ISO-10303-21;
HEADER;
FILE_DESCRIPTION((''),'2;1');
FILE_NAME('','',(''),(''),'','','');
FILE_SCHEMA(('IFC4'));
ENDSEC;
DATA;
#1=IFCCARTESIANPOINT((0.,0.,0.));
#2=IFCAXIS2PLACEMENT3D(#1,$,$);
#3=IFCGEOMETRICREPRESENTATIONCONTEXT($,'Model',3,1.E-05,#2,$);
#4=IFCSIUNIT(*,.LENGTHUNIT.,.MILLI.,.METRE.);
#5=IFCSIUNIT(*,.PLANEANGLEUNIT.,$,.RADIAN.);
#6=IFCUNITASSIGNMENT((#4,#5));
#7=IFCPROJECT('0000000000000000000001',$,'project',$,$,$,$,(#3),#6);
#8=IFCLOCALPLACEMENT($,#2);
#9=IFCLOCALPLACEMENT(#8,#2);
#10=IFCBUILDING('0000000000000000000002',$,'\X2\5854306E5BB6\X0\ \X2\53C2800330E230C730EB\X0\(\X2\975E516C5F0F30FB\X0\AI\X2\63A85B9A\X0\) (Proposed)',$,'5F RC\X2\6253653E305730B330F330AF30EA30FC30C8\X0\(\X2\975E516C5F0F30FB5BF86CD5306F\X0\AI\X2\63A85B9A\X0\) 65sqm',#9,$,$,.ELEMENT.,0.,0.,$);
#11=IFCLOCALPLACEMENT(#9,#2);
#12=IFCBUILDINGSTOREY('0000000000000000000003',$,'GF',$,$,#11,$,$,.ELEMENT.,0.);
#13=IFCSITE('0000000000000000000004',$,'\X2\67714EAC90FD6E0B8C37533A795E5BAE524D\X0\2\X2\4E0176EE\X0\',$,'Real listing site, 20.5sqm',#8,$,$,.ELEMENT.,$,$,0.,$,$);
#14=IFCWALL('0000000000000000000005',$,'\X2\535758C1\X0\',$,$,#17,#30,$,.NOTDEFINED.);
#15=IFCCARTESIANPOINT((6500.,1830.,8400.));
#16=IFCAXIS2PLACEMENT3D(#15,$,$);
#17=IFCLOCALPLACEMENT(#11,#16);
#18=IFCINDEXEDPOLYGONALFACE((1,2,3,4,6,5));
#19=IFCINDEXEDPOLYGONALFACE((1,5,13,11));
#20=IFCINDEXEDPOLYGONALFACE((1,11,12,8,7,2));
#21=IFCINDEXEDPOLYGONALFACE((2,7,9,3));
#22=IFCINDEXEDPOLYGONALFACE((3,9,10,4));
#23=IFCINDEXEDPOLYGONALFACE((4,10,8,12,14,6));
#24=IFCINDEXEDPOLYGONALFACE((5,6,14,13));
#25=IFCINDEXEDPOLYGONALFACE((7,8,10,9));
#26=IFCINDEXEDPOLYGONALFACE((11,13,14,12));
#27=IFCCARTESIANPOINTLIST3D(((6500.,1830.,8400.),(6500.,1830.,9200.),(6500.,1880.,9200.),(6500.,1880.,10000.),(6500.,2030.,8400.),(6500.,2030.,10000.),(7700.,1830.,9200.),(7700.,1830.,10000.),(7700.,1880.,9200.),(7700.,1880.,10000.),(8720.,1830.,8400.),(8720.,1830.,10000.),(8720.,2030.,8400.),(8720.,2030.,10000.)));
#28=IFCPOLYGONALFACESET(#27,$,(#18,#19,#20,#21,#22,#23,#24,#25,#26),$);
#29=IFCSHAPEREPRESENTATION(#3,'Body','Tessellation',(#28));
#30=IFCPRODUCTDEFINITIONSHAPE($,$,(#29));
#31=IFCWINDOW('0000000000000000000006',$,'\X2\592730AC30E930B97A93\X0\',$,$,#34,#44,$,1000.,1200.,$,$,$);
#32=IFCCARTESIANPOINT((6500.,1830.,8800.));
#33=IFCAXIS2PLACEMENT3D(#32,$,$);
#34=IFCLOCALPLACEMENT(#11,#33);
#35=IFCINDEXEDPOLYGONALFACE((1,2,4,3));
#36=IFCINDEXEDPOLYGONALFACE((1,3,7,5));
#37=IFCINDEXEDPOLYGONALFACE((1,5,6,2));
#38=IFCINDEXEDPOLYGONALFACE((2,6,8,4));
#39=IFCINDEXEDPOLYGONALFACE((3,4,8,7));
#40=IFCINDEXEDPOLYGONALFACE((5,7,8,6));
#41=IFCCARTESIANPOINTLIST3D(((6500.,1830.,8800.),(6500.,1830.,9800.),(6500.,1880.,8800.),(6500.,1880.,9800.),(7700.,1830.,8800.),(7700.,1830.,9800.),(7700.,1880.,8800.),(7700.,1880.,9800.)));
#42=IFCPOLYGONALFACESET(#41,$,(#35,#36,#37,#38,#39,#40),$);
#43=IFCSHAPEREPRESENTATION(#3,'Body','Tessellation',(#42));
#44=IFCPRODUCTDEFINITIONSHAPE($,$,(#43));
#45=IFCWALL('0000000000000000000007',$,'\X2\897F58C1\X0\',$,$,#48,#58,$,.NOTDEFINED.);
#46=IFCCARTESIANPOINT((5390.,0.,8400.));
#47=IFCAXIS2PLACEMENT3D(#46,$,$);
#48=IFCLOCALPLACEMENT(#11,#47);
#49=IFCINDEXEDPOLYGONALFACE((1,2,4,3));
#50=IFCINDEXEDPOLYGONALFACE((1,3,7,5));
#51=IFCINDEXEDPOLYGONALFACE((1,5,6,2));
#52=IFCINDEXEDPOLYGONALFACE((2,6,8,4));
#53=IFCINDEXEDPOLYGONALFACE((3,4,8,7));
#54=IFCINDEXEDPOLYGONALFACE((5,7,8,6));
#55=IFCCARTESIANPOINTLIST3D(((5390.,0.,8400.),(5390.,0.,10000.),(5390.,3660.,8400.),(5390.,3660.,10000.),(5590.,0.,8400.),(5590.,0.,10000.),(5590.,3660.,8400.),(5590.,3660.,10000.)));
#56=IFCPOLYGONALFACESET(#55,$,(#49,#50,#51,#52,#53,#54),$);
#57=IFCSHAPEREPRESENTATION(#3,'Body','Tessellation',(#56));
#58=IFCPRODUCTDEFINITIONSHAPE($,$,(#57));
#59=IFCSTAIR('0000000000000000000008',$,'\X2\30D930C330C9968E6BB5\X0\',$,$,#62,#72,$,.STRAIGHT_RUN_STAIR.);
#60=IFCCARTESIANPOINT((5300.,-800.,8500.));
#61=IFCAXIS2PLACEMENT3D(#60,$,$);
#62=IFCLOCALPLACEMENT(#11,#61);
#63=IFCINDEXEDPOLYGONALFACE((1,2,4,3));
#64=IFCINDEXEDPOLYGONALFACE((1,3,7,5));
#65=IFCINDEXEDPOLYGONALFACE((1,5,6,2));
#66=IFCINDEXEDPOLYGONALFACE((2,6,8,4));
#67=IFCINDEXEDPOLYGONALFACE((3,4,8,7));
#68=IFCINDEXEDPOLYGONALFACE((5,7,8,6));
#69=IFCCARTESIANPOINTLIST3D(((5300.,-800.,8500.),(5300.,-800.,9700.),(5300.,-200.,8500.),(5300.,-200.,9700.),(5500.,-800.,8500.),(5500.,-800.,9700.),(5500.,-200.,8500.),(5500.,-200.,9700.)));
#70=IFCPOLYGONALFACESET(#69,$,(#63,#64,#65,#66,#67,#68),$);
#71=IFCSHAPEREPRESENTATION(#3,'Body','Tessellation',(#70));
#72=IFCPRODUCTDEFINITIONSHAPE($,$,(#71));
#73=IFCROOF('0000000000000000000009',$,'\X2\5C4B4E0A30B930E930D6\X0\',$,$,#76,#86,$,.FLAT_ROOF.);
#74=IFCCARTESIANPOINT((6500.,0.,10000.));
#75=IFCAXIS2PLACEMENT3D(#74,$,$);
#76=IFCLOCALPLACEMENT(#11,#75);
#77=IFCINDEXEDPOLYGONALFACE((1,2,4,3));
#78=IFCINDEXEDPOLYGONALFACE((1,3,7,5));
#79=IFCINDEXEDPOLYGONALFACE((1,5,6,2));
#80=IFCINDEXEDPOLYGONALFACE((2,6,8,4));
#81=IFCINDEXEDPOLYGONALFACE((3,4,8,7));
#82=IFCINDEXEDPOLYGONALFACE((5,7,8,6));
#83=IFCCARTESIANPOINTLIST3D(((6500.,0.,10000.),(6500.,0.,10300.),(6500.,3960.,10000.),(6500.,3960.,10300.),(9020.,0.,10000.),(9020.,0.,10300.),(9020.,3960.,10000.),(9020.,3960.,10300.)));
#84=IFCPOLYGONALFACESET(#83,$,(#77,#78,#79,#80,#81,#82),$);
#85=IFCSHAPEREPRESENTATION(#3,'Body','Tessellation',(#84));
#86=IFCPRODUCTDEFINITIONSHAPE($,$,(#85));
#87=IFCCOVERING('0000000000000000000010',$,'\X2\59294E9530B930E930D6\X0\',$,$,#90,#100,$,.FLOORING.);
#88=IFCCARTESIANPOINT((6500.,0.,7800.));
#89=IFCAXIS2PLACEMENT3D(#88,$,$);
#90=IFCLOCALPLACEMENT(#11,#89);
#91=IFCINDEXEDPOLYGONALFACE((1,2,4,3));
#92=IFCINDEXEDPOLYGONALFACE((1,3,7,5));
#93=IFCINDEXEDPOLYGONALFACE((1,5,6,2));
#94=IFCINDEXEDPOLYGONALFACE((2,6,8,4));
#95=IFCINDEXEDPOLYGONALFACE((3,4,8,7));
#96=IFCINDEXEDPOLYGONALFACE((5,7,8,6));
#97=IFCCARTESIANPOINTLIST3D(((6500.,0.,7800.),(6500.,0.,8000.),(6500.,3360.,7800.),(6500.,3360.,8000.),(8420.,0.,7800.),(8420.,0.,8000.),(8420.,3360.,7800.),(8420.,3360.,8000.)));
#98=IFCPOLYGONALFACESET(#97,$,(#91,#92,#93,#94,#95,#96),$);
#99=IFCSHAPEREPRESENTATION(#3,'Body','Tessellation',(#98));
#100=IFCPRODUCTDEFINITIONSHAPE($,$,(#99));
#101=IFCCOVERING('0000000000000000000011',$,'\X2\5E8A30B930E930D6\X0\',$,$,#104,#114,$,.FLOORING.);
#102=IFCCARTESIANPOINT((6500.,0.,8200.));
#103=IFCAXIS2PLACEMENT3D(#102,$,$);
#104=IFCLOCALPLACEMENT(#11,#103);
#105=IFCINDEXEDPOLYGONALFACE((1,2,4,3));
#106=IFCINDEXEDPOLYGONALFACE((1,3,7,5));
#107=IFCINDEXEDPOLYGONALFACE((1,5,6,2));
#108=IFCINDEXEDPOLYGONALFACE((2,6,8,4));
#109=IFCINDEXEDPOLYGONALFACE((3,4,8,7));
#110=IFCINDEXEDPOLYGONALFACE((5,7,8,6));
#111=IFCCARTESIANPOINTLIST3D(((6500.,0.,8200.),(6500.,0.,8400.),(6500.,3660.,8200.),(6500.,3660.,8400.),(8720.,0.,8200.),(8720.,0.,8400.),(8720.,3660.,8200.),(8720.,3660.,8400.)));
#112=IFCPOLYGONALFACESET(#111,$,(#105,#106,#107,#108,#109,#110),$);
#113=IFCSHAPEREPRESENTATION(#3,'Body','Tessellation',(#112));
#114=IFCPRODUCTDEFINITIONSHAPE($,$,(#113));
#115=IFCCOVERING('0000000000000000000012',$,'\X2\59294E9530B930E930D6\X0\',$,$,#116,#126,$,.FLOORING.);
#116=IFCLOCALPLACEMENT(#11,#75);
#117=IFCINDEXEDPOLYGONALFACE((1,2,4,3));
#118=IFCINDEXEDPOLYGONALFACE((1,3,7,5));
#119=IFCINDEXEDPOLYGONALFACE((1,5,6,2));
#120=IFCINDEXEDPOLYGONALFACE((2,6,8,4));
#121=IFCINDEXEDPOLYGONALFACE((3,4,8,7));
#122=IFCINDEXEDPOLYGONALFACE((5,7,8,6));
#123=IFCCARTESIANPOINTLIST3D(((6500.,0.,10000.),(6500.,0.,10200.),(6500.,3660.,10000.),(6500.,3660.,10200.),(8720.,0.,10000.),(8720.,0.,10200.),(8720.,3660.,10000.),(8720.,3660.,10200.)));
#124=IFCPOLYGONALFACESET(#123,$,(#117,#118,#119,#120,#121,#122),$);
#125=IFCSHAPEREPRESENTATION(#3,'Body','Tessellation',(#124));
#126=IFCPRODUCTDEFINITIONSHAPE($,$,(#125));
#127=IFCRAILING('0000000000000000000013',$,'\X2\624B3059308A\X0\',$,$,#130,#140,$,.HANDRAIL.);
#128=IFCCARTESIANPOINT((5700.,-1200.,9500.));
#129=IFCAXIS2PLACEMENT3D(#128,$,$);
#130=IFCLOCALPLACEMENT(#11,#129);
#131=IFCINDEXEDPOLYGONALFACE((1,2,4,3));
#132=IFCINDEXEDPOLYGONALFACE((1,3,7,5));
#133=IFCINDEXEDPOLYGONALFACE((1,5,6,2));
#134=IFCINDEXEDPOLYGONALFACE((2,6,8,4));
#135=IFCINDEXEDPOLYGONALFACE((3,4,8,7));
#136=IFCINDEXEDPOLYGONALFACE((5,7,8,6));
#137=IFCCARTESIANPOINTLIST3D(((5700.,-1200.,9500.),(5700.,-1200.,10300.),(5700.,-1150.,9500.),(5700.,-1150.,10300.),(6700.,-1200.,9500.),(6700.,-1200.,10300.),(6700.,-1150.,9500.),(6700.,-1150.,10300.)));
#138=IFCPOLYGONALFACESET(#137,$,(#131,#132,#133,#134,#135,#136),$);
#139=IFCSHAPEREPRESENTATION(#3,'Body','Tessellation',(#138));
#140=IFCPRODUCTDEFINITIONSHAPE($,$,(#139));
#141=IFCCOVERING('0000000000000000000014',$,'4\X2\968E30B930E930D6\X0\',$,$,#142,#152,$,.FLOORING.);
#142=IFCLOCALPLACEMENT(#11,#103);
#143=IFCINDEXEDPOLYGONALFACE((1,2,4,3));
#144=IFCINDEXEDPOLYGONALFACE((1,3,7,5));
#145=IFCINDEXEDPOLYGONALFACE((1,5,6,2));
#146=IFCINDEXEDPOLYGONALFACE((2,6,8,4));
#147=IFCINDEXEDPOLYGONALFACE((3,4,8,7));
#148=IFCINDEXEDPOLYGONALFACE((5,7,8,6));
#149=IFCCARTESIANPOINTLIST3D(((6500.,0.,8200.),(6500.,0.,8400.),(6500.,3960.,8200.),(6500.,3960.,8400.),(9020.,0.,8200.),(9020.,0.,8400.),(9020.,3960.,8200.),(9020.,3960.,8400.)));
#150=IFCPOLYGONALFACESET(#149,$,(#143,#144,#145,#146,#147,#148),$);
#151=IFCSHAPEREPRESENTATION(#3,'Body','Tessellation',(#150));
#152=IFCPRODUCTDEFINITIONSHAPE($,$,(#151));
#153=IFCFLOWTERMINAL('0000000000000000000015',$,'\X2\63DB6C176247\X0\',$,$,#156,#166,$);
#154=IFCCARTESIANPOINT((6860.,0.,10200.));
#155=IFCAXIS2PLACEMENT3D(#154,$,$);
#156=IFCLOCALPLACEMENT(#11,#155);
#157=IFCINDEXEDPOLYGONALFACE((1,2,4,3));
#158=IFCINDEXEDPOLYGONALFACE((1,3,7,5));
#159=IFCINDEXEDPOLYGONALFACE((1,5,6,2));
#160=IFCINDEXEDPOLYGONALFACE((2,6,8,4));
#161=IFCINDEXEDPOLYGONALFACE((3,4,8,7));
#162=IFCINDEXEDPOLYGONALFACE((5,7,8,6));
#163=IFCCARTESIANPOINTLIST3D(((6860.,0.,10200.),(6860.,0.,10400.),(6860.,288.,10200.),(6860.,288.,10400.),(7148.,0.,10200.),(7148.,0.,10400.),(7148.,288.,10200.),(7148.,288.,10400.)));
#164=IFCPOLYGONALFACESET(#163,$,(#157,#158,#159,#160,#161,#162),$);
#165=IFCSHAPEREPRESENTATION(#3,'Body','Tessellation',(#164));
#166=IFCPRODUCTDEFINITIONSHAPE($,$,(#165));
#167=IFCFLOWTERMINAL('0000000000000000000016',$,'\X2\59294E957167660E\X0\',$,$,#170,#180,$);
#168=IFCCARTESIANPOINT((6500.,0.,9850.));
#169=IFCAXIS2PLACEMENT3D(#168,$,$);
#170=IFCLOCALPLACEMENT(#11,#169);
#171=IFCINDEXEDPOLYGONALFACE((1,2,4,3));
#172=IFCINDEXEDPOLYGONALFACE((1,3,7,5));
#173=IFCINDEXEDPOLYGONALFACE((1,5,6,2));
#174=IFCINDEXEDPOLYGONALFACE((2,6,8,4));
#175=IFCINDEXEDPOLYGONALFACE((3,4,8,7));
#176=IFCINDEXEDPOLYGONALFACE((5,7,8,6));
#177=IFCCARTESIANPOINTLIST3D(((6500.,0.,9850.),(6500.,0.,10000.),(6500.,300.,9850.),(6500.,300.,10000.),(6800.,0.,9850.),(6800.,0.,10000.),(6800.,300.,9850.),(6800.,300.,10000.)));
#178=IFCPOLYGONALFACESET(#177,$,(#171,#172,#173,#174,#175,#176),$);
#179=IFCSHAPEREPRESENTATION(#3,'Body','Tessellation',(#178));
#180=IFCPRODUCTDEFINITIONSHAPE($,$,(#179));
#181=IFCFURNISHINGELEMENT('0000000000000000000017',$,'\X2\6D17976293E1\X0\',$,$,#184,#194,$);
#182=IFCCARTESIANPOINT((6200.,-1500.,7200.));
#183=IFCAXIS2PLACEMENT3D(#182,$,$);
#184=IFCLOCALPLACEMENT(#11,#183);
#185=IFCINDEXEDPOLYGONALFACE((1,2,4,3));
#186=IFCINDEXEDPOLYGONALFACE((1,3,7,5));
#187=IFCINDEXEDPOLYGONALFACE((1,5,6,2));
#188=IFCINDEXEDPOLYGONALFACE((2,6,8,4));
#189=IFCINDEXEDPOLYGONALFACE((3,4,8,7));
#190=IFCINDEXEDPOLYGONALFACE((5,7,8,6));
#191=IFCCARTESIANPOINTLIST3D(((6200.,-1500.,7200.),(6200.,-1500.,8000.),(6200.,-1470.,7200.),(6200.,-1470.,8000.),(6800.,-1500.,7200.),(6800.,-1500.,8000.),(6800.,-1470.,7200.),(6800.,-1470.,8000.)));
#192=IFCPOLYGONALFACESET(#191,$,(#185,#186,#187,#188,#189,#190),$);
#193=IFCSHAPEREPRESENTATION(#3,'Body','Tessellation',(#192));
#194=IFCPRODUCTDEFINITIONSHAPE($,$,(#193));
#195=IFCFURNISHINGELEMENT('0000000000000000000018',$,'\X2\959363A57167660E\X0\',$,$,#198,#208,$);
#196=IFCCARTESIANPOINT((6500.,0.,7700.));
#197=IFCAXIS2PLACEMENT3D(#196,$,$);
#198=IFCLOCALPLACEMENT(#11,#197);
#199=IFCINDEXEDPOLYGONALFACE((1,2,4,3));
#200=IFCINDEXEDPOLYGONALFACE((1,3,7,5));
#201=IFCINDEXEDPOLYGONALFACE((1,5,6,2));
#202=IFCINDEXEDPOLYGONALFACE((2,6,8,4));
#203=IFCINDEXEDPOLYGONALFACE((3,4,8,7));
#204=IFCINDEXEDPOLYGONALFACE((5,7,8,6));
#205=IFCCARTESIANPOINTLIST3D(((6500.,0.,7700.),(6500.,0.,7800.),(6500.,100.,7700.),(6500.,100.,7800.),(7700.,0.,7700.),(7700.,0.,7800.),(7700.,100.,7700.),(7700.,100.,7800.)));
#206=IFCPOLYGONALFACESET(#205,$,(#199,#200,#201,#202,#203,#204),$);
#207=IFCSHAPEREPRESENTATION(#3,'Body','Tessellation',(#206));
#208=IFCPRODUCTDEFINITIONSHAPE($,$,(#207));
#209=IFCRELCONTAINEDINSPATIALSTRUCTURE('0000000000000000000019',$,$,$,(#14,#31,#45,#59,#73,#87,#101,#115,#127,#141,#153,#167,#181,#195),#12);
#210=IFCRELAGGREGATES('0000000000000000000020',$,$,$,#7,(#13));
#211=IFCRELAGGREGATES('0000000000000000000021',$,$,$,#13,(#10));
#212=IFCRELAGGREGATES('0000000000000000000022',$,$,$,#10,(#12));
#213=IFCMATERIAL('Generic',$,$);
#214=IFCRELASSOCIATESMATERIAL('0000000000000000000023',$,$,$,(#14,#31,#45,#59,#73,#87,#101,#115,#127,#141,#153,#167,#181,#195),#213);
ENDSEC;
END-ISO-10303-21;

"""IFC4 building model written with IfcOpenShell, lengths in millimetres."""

from ifc_helpers import new_model, si_unit, frame, frame_2d, origin, place, context, project, spatial, rectangle, extrude, material, element, fill, save


model = new_model("IFC4")

# Units and contexts
model_context = context("Model", 3, precision=1e-05, world=origin())
ifc_project = project(units=[si_unit("LENGTHUNIT", "METRE", prefix="MILLI"), si_unit("PLANEANGLEUNIT", "RADIAN")], contexts=[model_context])

# Site, building, storey
site_placement = place(None, origin())
site = spatial("IfcSite", under=ifc_project, at=site_placement, Name="東京都渋谷区神宮前2丁目", ObjectType="Real listing site, 20.5sqm", CompositionType="ELEMENT", RefElevation=0.0)
building_placement = place(site_placement, origin())
building = spatial("IfcBuilding", under=site, at=building_placement, Name="塔の家 参考モデル(非公式・AI推定) (Proposed)", ObjectType="5F RC打放しコンクリート(非公式・寸法はAI推定) 65sqm", CompositionType="ELEMENT", ElevationOfRefHeight=0.0, ElevationOfTerrain=0.0)
storey_placement = place(building_placement, origin())
storey = spatial("IfcBuildingStorey", under=building, at=storey_placement, Name="GF", CompositionType="ELEMENT", Elevation=0.0)

# Shared definitions
ifc_material = material(Name="Generic")

# Wall, opening, window
wall_1_placement = place(storey_placement, frame((6500.0, 1830.0, 8400.0)))
wall_1 = element("IfcWall", 1, at=wall_1_placement, inside=storey, material=ifc_material, Name="南壁", PredefinedType="NOTDEFINED", context=model_context, shape_type="SweptSolid", body=[
    extrude(rectangle(XDim=2220.0, YDim=200.0, at=frame_2d((1110.0, 100.0))), frame((6500.0, 1830.0, 8400.0)), (0.0, 0.0, 1.0), 1600.0),
])
opening_1_placement = place(storey_placement, frame((6500.0, 1830.0, 8800.0)))
opening_1 = element("IfcOpeningElement", 2, at=opening_1_placement, cuts=wall_1, PredefinedType="NOTDEFINED", context=model_context, shape_type="SweptSolid", body=[
    extrude(rectangle(XDim=1200.0, YDim=50.0, at=frame_2d((600.0, 25.0))), frame((6500.0, 1830.0, 8800.0)), (0.0, 0.0, 1.0), 1000.0),
])
window_1_placement = place(storey_placement, frame((6500.0, 1830.0, 8800.0)))
window_1 = element("IfcWindow", 3, at=window_1_placement, inside=storey, material=ifc_material, Name="大ガラス窓", OverallHeight=1000.0, OverallWidth=1200.0, context=model_context, shape_type="SweptSolid", body=[
    extrude(rectangle(XDim=1200.0, YDim=50.0, at=frame_2d((600.0, 25.0))), frame((6500.0, 1830.0, 8800.0)), (0.0, 0.0, 1.0), 1000.0),
])
fill(opening_1, window_1)

# Wall
wall_2_placement = place(storey_placement, frame((5390.0, 0.0, 8400.0)))
element("IfcWall", 4, at=wall_2_placement, inside=storey, material=ifc_material, Name="西壁", PredefinedType="NOTDEFINED", context=model_context, shape_type="SweptSolid", body=[
    extrude(rectangle(XDim=200.0, YDim=3660.0, at=frame_2d((100.0, 1830.0))), frame((5390.0, 0.0, 8400.0)), (0.0, 0.0, 1.0), 1600.0),
])

# Stair
stair_placement = place(storey_placement, frame((5300.0, -800.0, 8500.0)))
element("IfcStair", 5, at=stair_placement, inside=storey, material=ifc_material, Name="ベッド階段", PredefinedType="STRAIGHT_RUN_STAIR", context=model_context, shape_type="SweptSolid", body=[
    extrude(rectangle(XDim=200.0, YDim=600.0, at=frame_2d((100.0, 300.0))), frame((5300.0, -800.0, 8500.0)), (0.0, 0.0, 1.0), 1200.0),
])

# Roof
roof_placement = place(storey_placement, frame((6500.0, 0.0, 10000.0)))
element("IfcRoof", 6, at=roof_placement, inside=storey, material=ifc_material, Name="屋上スラブ", PredefinedType="FLAT_ROOF", context=model_context, shape_type="SweptSolid", body=[
    extrude(rectangle(XDim=2520.0, YDim=3960.0, at=frame_2d((1260.0, 1980.0))), frame((6500.0, 0.0, 10000.0)), (0.0, 0.0, 1.0), 300.0),
])

# Coverings
covering_1_placement = place(storey_placement, frame((6500.0, 0.0, 7800.0)))
element("IfcCovering", 7, at=covering_1_placement, inside=storey, material=ifc_material, Name="天井スラブ", PredefinedType="FLOORING", context=model_context, shape_type="SweptSolid", body=[
    extrude(rectangle(XDim=1920.0, YDim=3360.0, at=frame_2d((960.0, 1680.0))), frame((6500.0, 0.0, 7800.0)), (0.0, 0.0, 1.0), 200.0),
])
covering_2_placement = place(storey_placement, frame((6500.0, 0.0, 8200.0)))
element("IfcCovering", 8, at=covering_2_placement, inside=storey, material=ifc_material, Name="床スラブ", PredefinedType="FLOORING", context=model_context, shape_type="SweptSolid", body=[
    extrude(rectangle(XDim=2220.0, YDim=3660.0, at=frame_2d((1110.0, 1830.0))), frame((6500.0, 0.0, 8200.0)), (0.0, 0.0, 1.0), 200.0),
])
covering_3_placement = place(storey_placement, frame((6500.0, 0.0, 10000.0)))
element("IfcCovering", 9, at=covering_3_placement, inside=storey, material=ifc_material, Name="天井スラブ", PredefinedType="FLOORING", context=model_context, shape_type="SweptSolid", body=[
    extrude(rectangle(XDim=2220.0, YDim=3660.0, at=frame_2d((1110.0, 1830.0))), frame((6500.0, 0.0, 10000.0)), (0.0, 0.0, 1.0), 200.0),
])

# Railing
railing_placement = place(storey_placement, frame((5700.0, -1200.0, 9500.0)))
element("IfcRailing", 10, at=railing_placement, inside=storey, material=ifc_material, Name="手すり", PredefinedType="HANDRAIL", context=model_context, shape_type="SweptSolid", body=[
    extrude(rectangle(XDim=1000.0, YDim=50.0, at=frame_2d((500.0, 25.0))), frame((5700.0, -1200.0, 9500.0)), (0.0, 0.0, 1.0), 800.0),
])

# Covering
covering_4_placement = place(storey_placement, frame((6500.0, 0.0, 8200.0)))
element("IfcCovering", 11, at=covering_4_placement, inside=storey, material=ifc_material, Name="4階スラブ", PredefinedType="FLOORING", context=model_context, shape_type="SweptSolid", body=[
    extrude(rectangle(XDim=2520.0, YDim=3960.0, at=frame_2d((1260.0, 1980.0))), frame((6500.0, 0.0, 8200.0)), (0.0, 0.0, 1.0), 200.0),
])

# Flow terminals
flow_terminal_1_placement = place(storey_placement, frame((6860.0, 0.0, 10200.0)))
element("IfcFlowTerminal", 12, at=flow_terminal_1_placement, inside=storey, material=ifc_material, Name="換気扇", context=model_context, shape_type="SweptSolid", body=[
    extrude(rectangle(XDim=288.0, YDim=288.0, at=frame_2d((144.0, 144.0))), frame((6860.0, 0.0, 10200.0)), (0.0, 0.0, 1.0), 200.0),
])
flow_terminal_2_placement = place(storey_placement, frame((6500.0, 0.0, 9850.0)))
element("IfcFlowTerminal", 13, at=flow_terminal_2_placement, inside=storey, material=ifc_material, Name="天井照明", context=model_context, shape_type="SweptSolid", body=[
    extrude(rectangle(XDim=300.0, YDim=300.0, at=frame_2d((150.0, 150.0))), frame((6500.0, 0.0, 9850.0)), (0.0, 0.0, 1.0), 150.0),
])

# Furnishing elements
furnishing_1_placement = place(storey_placement, frame((6200.0, -1500.0, 7200.0)))
element("IfcFurnishingElement", 14, at=furnishing_1_placement, inside=storey, material=ifc_material, Name="洗面鏡", context=model_context, shape_type="SweptSolid", body=[
    extrude(rectangle(XDim=600.0, YDim=30.0, at=frame_2d((300.0, 15.0))), frame((6200.0, -1500.0, 7200.0)), (0.0, 0.0, 1.0), 800.0),
])
furnishing_2_placement = place(storey_placement, frame((6500.0, 0.0, 7700.0)))
element("IfcFurnishingElement", 15, at=furnishing_2_placement, inside=storey, material=ifc_material, Name="間接照明", context=model_context, shape_type="SweptSolid", body=[
    extrude(rectangle(XDim=1200.0, YDim=100.0, at=frame_2d((600.0, 50.0))), frame((6500.0, 0.0, 7700.0)), (0.0, 0.0, 1.0), 100.0),
])

save(model, "model.ifc")
